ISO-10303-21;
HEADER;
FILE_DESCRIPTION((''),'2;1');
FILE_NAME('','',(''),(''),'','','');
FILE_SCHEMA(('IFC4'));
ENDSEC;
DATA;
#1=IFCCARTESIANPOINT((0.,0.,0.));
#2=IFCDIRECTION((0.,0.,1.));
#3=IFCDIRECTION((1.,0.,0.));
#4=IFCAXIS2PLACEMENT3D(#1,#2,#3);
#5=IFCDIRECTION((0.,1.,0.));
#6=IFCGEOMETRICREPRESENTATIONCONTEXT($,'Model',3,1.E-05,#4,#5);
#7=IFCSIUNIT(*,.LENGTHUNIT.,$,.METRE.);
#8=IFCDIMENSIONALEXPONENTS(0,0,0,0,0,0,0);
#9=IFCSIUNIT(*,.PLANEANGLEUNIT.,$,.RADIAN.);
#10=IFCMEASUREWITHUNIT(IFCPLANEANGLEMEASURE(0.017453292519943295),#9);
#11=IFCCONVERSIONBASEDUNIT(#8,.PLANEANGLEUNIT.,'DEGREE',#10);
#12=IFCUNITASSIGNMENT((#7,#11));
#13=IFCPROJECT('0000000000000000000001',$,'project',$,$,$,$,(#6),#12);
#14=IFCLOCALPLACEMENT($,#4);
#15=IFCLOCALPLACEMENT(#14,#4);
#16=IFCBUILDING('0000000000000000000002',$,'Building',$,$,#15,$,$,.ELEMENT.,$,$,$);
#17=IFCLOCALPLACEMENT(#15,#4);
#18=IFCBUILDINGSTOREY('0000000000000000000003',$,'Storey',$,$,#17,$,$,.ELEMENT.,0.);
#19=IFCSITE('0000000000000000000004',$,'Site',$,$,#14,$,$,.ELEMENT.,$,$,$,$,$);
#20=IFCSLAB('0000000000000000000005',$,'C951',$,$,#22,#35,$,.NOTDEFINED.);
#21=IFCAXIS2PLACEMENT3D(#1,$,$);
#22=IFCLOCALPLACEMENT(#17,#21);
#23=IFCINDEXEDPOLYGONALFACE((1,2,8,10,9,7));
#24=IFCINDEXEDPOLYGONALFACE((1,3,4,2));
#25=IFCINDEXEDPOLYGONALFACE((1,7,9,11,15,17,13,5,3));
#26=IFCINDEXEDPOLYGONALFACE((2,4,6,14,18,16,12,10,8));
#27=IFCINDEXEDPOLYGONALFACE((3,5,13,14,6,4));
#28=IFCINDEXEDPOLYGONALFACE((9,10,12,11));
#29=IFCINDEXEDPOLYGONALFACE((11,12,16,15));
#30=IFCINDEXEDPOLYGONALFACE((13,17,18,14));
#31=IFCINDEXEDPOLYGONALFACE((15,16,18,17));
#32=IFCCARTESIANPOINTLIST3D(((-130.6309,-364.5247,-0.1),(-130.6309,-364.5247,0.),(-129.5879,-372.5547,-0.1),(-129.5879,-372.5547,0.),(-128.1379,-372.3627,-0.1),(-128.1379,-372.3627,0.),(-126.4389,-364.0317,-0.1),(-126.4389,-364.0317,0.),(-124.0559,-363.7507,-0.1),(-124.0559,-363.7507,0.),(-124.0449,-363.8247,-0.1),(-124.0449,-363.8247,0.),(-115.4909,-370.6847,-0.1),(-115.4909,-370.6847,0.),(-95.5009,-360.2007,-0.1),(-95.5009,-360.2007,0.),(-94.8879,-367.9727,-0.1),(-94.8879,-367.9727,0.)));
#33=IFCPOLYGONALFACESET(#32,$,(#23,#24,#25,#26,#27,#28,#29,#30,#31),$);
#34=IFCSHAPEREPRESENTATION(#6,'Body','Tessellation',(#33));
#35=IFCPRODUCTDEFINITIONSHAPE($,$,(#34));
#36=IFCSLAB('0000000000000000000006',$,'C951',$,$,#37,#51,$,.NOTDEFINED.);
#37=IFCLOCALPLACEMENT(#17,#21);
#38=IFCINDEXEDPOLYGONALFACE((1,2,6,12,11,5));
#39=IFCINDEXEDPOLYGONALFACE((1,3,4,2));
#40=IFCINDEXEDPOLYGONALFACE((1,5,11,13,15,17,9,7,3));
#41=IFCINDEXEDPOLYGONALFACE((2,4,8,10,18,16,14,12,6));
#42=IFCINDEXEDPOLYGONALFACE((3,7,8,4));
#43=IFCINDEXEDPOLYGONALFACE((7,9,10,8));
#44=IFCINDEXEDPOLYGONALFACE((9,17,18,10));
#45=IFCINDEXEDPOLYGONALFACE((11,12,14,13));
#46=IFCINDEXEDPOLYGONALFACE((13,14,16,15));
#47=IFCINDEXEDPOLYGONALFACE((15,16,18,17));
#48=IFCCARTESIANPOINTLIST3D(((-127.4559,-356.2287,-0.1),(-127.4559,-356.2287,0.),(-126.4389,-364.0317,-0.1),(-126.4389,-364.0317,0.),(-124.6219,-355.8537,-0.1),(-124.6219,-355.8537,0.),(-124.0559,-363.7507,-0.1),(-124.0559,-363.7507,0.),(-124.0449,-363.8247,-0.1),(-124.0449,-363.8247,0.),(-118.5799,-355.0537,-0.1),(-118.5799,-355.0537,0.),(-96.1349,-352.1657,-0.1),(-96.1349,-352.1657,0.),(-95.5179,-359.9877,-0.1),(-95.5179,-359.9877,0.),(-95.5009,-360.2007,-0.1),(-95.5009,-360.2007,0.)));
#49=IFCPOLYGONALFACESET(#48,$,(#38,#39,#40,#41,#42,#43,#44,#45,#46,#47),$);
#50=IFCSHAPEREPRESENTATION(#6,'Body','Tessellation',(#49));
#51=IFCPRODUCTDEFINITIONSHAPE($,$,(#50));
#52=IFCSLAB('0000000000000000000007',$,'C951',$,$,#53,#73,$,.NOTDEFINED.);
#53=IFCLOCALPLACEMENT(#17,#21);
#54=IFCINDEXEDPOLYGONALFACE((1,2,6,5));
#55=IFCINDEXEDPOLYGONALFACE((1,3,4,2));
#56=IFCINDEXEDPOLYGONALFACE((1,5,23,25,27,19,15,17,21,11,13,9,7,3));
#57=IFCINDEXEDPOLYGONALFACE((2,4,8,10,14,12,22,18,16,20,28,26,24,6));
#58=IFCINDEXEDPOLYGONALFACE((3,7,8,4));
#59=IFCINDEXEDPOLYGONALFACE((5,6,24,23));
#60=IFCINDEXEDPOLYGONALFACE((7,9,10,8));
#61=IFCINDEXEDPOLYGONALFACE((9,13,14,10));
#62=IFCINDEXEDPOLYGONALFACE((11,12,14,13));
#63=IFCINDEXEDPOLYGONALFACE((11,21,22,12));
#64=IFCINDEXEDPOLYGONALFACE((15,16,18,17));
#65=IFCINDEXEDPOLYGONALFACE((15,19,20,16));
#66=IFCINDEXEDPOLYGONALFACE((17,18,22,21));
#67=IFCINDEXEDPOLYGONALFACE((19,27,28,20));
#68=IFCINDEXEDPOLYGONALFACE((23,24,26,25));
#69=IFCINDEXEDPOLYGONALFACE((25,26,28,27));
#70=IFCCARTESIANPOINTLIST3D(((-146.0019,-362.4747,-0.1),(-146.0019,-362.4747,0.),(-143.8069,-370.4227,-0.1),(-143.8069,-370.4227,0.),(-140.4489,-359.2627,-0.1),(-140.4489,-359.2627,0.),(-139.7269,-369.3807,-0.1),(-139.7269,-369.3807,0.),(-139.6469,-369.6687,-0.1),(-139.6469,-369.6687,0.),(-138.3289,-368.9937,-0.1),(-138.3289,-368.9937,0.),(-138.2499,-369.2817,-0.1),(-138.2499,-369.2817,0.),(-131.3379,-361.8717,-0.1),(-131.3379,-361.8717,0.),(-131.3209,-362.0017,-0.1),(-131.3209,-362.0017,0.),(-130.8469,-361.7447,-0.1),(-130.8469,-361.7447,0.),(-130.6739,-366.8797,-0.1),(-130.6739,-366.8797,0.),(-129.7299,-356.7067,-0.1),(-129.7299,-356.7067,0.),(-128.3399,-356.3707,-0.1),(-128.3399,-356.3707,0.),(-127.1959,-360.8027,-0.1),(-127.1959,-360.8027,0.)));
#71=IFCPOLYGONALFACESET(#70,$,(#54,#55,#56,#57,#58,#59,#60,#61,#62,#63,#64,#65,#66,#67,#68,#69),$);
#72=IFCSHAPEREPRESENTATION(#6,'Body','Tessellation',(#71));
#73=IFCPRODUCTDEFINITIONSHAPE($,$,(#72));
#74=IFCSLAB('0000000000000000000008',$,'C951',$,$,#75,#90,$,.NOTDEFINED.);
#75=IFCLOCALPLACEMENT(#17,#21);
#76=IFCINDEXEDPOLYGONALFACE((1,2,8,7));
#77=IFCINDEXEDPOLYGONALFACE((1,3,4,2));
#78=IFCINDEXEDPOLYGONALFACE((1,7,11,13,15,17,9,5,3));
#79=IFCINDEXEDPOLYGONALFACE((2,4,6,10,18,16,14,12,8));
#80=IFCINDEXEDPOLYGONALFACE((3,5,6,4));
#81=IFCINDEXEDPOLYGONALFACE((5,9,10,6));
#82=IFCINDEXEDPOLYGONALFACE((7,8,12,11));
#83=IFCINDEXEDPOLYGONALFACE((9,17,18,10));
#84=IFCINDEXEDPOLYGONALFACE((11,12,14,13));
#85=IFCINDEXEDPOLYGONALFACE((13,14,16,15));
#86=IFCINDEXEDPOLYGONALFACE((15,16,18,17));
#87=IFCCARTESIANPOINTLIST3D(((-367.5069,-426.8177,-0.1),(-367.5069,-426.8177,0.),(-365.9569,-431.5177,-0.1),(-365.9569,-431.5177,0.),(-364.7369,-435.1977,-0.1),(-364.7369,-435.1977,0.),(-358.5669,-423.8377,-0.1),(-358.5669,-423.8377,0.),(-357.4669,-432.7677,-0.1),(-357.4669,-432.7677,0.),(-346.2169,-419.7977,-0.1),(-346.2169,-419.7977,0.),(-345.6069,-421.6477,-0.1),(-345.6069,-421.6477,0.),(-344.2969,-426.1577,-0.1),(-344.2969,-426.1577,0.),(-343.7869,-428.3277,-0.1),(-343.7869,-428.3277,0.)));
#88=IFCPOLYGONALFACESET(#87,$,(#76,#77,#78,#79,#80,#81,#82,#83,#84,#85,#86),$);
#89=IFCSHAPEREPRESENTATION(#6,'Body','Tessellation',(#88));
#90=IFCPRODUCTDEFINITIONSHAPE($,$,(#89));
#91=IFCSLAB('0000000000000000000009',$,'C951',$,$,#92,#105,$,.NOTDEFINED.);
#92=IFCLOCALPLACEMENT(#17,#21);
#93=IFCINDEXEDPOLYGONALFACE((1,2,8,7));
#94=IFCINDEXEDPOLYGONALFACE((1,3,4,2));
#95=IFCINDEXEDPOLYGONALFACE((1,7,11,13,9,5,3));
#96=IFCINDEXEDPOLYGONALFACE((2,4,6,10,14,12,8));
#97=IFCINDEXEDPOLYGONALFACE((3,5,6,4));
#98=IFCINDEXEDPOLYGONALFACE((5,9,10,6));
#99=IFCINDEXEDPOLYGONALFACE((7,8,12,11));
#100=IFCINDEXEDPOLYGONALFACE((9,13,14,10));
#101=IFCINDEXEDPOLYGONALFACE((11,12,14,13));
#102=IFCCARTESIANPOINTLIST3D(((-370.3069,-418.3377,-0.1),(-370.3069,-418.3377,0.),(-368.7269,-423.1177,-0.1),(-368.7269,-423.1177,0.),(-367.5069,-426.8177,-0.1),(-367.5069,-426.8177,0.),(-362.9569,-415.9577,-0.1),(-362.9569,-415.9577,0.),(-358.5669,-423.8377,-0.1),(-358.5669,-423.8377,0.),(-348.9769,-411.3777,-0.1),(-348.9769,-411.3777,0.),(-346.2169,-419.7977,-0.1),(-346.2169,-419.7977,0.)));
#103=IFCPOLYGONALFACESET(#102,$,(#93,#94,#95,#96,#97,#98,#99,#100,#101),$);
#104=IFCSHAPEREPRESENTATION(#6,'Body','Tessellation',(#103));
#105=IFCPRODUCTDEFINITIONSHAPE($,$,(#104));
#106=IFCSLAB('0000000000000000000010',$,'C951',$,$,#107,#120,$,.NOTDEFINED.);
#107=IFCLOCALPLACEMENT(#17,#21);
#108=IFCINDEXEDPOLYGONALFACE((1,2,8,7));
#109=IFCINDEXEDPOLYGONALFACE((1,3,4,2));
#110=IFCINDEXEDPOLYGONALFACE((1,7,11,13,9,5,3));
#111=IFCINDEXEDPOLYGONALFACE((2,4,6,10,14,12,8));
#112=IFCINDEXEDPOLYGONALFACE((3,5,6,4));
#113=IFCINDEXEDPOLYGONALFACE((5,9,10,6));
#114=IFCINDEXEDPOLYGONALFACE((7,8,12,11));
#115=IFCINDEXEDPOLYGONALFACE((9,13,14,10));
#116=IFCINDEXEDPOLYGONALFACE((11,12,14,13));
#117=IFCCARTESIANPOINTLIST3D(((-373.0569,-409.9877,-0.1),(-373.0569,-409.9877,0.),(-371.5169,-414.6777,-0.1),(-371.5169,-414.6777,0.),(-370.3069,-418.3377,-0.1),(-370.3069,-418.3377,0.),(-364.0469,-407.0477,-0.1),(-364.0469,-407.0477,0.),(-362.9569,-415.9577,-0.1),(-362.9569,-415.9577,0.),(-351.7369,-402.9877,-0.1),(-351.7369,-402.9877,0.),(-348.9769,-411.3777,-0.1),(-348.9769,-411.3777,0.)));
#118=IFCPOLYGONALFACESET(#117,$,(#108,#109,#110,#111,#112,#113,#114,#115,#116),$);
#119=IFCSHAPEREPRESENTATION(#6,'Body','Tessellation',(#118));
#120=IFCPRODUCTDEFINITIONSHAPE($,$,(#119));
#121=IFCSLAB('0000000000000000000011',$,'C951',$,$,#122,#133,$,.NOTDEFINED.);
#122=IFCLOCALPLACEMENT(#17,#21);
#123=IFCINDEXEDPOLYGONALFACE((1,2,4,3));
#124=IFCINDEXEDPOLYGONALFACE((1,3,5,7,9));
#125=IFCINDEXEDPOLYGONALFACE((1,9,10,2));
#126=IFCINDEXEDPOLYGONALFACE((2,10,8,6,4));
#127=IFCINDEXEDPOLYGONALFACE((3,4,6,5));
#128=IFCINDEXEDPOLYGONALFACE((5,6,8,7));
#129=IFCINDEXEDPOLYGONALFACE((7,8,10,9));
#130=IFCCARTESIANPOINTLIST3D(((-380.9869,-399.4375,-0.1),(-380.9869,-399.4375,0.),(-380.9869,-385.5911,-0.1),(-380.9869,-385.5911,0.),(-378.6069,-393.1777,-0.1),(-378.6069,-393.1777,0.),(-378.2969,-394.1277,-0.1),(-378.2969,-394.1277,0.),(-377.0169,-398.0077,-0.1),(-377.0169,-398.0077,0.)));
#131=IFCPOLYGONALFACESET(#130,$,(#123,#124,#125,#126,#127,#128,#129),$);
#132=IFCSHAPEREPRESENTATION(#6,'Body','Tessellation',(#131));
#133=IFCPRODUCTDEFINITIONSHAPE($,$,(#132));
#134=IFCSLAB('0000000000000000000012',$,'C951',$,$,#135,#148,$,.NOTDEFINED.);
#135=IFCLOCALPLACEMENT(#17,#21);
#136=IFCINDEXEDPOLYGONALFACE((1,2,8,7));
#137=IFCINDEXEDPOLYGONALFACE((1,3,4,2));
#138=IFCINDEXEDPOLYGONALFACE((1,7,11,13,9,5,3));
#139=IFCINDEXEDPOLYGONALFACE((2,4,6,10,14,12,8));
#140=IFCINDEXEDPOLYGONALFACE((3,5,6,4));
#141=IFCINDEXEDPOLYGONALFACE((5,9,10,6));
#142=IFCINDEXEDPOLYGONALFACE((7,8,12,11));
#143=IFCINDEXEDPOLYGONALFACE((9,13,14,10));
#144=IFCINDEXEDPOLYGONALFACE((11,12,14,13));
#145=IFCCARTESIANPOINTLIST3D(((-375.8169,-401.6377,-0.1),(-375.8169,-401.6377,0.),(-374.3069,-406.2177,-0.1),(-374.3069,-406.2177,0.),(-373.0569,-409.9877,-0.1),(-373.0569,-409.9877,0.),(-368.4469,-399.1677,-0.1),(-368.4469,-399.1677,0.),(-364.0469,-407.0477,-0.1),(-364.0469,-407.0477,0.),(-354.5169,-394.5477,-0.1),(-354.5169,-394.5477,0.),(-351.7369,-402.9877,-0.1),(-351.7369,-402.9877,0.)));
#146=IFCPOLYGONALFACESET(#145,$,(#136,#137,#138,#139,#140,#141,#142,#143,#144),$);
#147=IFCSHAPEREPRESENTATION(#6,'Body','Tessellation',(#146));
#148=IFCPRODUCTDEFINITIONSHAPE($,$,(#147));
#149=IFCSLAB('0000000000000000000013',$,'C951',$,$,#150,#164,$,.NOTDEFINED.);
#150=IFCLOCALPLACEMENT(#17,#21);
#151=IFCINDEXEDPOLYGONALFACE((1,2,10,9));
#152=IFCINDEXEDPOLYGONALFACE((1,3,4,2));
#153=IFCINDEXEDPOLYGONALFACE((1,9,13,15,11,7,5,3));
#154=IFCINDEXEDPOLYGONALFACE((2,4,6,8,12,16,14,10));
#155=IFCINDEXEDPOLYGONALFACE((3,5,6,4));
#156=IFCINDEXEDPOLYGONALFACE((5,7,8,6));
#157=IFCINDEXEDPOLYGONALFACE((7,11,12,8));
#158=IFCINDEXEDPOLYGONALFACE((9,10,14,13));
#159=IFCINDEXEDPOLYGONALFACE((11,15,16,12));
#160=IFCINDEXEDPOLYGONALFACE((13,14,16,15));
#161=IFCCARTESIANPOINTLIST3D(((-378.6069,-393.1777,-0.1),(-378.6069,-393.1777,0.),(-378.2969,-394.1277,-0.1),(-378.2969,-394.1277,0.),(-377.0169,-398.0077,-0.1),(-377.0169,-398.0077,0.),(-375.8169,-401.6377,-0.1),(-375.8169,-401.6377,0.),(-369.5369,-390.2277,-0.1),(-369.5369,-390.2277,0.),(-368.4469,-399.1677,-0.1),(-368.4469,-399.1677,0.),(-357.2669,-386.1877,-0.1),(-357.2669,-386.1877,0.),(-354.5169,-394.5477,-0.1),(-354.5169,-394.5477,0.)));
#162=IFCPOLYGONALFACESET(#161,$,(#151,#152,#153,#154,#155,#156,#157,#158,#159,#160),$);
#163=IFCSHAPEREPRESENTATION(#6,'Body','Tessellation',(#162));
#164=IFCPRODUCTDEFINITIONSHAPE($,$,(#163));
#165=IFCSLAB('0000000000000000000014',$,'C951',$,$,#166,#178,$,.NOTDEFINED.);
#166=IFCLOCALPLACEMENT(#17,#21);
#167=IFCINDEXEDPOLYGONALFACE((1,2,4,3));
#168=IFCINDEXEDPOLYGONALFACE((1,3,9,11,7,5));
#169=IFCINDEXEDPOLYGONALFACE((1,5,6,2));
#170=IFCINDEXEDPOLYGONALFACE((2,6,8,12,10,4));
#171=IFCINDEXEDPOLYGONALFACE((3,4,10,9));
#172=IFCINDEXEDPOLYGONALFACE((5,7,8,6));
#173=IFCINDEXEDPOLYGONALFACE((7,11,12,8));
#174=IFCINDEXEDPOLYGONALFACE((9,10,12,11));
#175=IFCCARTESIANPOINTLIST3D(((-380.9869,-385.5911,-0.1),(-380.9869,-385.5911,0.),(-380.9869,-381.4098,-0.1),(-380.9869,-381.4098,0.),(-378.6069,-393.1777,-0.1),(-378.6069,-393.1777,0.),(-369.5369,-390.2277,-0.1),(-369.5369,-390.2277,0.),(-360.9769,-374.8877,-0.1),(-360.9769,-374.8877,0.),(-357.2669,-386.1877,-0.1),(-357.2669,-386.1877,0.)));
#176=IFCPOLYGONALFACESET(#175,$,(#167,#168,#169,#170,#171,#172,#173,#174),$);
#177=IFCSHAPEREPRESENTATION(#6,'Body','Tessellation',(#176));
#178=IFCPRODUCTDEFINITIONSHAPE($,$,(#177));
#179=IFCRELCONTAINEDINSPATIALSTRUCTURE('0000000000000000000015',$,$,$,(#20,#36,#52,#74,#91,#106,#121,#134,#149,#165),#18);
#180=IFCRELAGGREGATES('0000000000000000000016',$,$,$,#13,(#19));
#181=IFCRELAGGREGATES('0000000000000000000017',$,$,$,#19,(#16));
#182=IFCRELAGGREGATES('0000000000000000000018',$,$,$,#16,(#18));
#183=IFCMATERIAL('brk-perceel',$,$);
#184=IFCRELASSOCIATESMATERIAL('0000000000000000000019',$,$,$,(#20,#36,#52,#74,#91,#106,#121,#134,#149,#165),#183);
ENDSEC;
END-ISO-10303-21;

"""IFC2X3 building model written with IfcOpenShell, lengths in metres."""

from ifc_helpers import new_model, entity, si_unit, converted_unit, direction, frame, origin_with_axes, place, context, project, spatial, polyline, outline, extrude, material, element, save


model = new_model("IFC2X3")

# Units and contexts
model_context = context("Model", 3, precision=1e-05, world=origin_with_axes(), true_north=direction((0.0, 1.0, 0.0)))
ifc_project = project(units=[si_unit("LENGTHUNIT", "METRE"), converted_unit("PLANEANGLEUNIT", "DEGREE", entity("IfcPlaneAngleMeasure", 0.017453292519943295), si_unit("PLANEANGLEUNIT", "RADIAN"), dimensions=[0, 0, 0, 0, 0, 0, 0])], contexts=[model_context])

# Site, building, storey
site_placement = place(None, origin_with_axes())
site = spatial("IfcSite", under=ifc_project, at=site_placement, Name="Site", CompositionType="ELEMENT")
building_placement = place(site_placement, origin_with_axes())
building = spatial("IfcBuilding", under=site, at=building_placement, Name="Building", CompositionType="ELEMENT")
storey_placement = place(building_placement, origin_with_axes())
storey = spatial("IfcBuildingStorey", under=building, at=storey_placement, Name="Storey", CompositionType="ELEMENT", Elevation=0.0)

# Slabs
ifc_material = material(Name="brk-perceel")
slab_1_placement = place(storey_placement, frame((0.0, 0.0, -0.1), z_axis=(0.0, 0.0, 1.0), x_axis=(1.0, 0.0, 0.0)))
element("IfcSlab", 1, at=slab_1_placement, inside=storey, material=ifc_material, Name="C951", PredefinedType="NOTDEFINED", context=model_context, shape_type="SweptSolid", body=[
    extrude(outline(polyline([(-129.5879, -372.5547), (-130.6309, -364.5247), (-126.4389, -364.0317), (-124.0559, -363.7507), (-124.0449, -363.8247), (-95.5009, -360.2007), (-94.8879, -367.9727), (-115.4909, -370.6847), (-128.1379, -372.3627), (-129.5879, -372.5547)])), origin_with_axes(), (0.0, 0.0, 1.0), 0.1),
])
slab_2_placement = place(storey_placement, frame((0.0, 0.0, -0.1), z_axis=(0.0, 0.0, 1.0), x_axis=(1.0, 0.0, 0.0)))
element("IfcSlab", 2, at=slab_2_placement, inside=storey, material=ifc_material, Name="C951", PredefinedType="NOTDEFINED", context=model_context, shape_type="SweptSolid", body=[
    extrude(outline(polyline([(-124.0559, -363.7507), (-126.4389, -364.0317), (-127.4559, -356.2287), (-124.6219, -355.8537), (-118.5799, -355.0537), (-96.1349, -352.1657), (-95.5179, -359.9877), (-95.5009, -360.2007), (-124.0449, -363.8247), (-124.0559, -363.7507)])), origin_with_axes(), (0.0, 0.0, 1.0), 0.1),
])
slab_3_placement = place(storey_placement, frame((0.0, 0.0, -0.1), z_axis=(0.0, 0.0, 1.0), x_axis=(1.0, 0.0, 0.0)))
element("IfcSlab", 3, at=slab_3_placement, inside=storey, material=ifc_material, Name="C951", PredefinedType="NOTDEFINED", context=model_context, shape_type="SweptSolid", body=[
    extrude(outline(polyline([(-138.3289, -368.9937), (-138.2499, -369.2817), (-139.6469, -369.6687), (-139.7269, -369.3807), (-143.8069, -370.4227), (-146.0019, -362.4747), (-140.4489, -359.2627), (-129.7299, -356.7067), (-128.3399, -356.3707), (-127.1959, -360.8027), (-130.8469, -361.7447), (-131.3379, -361.8717), (-131.3209, -362.0017), (-130.6739, -366.8797), (-138.3289, -368.9937)])), origin_with_axes(), (0.0, 0.0, 1.0), 0.1),
])
slab_4_placement = place(storey_placement, frame((0.0, 0.0, -0.1), z_axis=(0.0, 0.0, 1.0), x_axis=(1.0, 0.0, 0.0)))
element("IfcSlab", 4, at=slab_4_placement, inside=storey, material=ifc_material, Name="C951", PredefinedType="NOTDEFINED", context=model_context, shape_type="SweptSolid", body=[
    extrude(outline(polyline([(-345.6069, -421.6477), (-344.2969, -426.1577), (-343.7869, -428.3277), (-357.4669, -432.7677), (-364.7369, -435.1977), (-365.9569, -431.5177), (-367.5069, -426.8177), (-358.5669, -423.8377), (-346.2169, -419.7977), (-345.6069, -421.6477)])), origin_with_axes(), (0.0, 0.0, 1.0), 0.1),
])
slab_5_placement = place(storey_placement, frame((0.0, 0.0, -0.1), z_axis=(0.0, 0.0, 1.0), x_axis=(1.0, 0.0, 0.0)))
element("IfcSlab", 5, at=slab_5_placement, inside=storey, material=ifc_material, Name="C951", PredefinedType="NOTDEFINED", context=model_context, shape_type="SweptSolid", body=[
    extrude(outline(polyline([(-346.2169, -419.7977), (-358.5669, -423.8377), (-367.5069, -426.8177), (-368.7269, -423.1177), (-370.3069, -418.3377), (-362.9569, -415.9577), (-348.9769, -411.3777), (-346.2169, -419.7977)])), origin_with_axes(), (0.0, 0.0, 1.0), 0.1),
])
slab_6_placement = place(storey_placement, frame((0.0, 0.0, -0.1), z_axis=(0.0, 0.0, 1.0), x_axis=(1.0, 0.0, 0.0)))
element("IfcSlab", 6, at=slab_6_placement, inside=storey, material=ifc_material, Name="C951", PredefinedType="NOTDEFINED", context=model_context, shape_type="SweptSolid", body=[
    extrude(outline(polyline([(-348.9769, -411.3777), (-362.9569, -415.9577), (-370.3069, -418.3377), (-371.5169, -414.6777), (-373.0569, -409.9877), (-364.0469, -407.0477), (-351.7369, -402.9877), (-348.9769, -411.3777)])), origin_with_axes(), (0.0, 0.0, 1.0), 0.1),
])
slab_7_placement = place(storey_placement, frame((0.0, 0.0, -0.1), z_axis=(0.0, 0.0, 1.0), x_axis=(1.0, 0.0, 0.0)))
element("IfcSlab", 7, at=slab_7_placement, inside=storey, material=ifc_material, Name="C951", PredefinedType="NOTDEFINED", context=model_context, shape_type="SweptSolid", body=[
    extrude(outline(polyline([(-378.6069, -393.1777), (-378.2969, -394.1277), (-377.0169, -398.0077), (-380.9869, -399.4375), (-380.9869, -385.5911), (-378.6069, -393.1777)])), origin_with_axes(), (0.0, 0.0, 1.0), 0.1),
])
slab_8_placement = place(storey_placement, frame((0.0, 0.0, -0.1), z_axis=(0.0, 0.0, 1.0), x_axis=(1.0, 0.0, 0.0)))
element("IfcSlab", 8, at=slab_8_placement, inside=storey, material=ifc_material, Name="C951", PredefinedType="NOTDEFINED", context=model_context, shape_type="SweptSolid", body=[
    extrude(outline(polyline([(-351.7369, -402.9877), (-364.0469, -407.0477), (-373.0569, -409.9877), (-374.3069, -406.2177), (-375.8169, -401.6377), (-368.4469, -399.1677), (-354.5169, -394.5477), (-351.7369, -402.9877)])), origin_with_axes(), (0.0, 0.0, 1.0), 0.1),
])
slab_9_placement = place(storey_placement, frame((0.0, 0.0, -0.1), z_axis=(0.0, 0.0, 1.0), x_axis=(1.0, 0.0, 0.0)))
element("IfcSlab", 9, at=slab_9_placement, inside=storey, material=ifc_material, Name="C951", PredefinedType="NOTDEFINED", context=model_context, shape_type="SweptSolid", body=[
    extrude(outline(polyline([(-354.5169, -394.5477), (-368.4469, -399.1677), (-375.8169, -401.6377), (-377.0169, -398.0077), (-378.2969, -394.1277), (-378.6069, -393.1777), (-369.5369, -390.2277), (-357.2669, -386.1877), (-354.5169, -394.5477)])), origin_with_axes(), (0.0, 0.0, 1.0), 0.1),
])
slab_10_placement = place(storey_placement, frame((0.0, 0.0, -0.1), z_axis=(0.0, 0.0, 1.0), x_axis=(1.0, 0.0, 0.0)))
element("IfcSlab", 10, at=slab_10_placement, inside=storey, material=ifc_material, Name="C951", PredefinedType="NOTDEFINED", context=model_context, shape_type="SweptSolid", body=[
    extrude(outline(polyline([(-360.9769, -374.8877), (-357.2669, -386.1877), (-369.5369, -390.2277), (-378.6069, -393.1777), (-380.9869, -385.5911), (-380.9869, -381.4098), (-360.9769, -374.8877)])), origin_with_axes(), (0.0, 0.0, 1.0), 0.1),
])

save(model, "model.ifc")
